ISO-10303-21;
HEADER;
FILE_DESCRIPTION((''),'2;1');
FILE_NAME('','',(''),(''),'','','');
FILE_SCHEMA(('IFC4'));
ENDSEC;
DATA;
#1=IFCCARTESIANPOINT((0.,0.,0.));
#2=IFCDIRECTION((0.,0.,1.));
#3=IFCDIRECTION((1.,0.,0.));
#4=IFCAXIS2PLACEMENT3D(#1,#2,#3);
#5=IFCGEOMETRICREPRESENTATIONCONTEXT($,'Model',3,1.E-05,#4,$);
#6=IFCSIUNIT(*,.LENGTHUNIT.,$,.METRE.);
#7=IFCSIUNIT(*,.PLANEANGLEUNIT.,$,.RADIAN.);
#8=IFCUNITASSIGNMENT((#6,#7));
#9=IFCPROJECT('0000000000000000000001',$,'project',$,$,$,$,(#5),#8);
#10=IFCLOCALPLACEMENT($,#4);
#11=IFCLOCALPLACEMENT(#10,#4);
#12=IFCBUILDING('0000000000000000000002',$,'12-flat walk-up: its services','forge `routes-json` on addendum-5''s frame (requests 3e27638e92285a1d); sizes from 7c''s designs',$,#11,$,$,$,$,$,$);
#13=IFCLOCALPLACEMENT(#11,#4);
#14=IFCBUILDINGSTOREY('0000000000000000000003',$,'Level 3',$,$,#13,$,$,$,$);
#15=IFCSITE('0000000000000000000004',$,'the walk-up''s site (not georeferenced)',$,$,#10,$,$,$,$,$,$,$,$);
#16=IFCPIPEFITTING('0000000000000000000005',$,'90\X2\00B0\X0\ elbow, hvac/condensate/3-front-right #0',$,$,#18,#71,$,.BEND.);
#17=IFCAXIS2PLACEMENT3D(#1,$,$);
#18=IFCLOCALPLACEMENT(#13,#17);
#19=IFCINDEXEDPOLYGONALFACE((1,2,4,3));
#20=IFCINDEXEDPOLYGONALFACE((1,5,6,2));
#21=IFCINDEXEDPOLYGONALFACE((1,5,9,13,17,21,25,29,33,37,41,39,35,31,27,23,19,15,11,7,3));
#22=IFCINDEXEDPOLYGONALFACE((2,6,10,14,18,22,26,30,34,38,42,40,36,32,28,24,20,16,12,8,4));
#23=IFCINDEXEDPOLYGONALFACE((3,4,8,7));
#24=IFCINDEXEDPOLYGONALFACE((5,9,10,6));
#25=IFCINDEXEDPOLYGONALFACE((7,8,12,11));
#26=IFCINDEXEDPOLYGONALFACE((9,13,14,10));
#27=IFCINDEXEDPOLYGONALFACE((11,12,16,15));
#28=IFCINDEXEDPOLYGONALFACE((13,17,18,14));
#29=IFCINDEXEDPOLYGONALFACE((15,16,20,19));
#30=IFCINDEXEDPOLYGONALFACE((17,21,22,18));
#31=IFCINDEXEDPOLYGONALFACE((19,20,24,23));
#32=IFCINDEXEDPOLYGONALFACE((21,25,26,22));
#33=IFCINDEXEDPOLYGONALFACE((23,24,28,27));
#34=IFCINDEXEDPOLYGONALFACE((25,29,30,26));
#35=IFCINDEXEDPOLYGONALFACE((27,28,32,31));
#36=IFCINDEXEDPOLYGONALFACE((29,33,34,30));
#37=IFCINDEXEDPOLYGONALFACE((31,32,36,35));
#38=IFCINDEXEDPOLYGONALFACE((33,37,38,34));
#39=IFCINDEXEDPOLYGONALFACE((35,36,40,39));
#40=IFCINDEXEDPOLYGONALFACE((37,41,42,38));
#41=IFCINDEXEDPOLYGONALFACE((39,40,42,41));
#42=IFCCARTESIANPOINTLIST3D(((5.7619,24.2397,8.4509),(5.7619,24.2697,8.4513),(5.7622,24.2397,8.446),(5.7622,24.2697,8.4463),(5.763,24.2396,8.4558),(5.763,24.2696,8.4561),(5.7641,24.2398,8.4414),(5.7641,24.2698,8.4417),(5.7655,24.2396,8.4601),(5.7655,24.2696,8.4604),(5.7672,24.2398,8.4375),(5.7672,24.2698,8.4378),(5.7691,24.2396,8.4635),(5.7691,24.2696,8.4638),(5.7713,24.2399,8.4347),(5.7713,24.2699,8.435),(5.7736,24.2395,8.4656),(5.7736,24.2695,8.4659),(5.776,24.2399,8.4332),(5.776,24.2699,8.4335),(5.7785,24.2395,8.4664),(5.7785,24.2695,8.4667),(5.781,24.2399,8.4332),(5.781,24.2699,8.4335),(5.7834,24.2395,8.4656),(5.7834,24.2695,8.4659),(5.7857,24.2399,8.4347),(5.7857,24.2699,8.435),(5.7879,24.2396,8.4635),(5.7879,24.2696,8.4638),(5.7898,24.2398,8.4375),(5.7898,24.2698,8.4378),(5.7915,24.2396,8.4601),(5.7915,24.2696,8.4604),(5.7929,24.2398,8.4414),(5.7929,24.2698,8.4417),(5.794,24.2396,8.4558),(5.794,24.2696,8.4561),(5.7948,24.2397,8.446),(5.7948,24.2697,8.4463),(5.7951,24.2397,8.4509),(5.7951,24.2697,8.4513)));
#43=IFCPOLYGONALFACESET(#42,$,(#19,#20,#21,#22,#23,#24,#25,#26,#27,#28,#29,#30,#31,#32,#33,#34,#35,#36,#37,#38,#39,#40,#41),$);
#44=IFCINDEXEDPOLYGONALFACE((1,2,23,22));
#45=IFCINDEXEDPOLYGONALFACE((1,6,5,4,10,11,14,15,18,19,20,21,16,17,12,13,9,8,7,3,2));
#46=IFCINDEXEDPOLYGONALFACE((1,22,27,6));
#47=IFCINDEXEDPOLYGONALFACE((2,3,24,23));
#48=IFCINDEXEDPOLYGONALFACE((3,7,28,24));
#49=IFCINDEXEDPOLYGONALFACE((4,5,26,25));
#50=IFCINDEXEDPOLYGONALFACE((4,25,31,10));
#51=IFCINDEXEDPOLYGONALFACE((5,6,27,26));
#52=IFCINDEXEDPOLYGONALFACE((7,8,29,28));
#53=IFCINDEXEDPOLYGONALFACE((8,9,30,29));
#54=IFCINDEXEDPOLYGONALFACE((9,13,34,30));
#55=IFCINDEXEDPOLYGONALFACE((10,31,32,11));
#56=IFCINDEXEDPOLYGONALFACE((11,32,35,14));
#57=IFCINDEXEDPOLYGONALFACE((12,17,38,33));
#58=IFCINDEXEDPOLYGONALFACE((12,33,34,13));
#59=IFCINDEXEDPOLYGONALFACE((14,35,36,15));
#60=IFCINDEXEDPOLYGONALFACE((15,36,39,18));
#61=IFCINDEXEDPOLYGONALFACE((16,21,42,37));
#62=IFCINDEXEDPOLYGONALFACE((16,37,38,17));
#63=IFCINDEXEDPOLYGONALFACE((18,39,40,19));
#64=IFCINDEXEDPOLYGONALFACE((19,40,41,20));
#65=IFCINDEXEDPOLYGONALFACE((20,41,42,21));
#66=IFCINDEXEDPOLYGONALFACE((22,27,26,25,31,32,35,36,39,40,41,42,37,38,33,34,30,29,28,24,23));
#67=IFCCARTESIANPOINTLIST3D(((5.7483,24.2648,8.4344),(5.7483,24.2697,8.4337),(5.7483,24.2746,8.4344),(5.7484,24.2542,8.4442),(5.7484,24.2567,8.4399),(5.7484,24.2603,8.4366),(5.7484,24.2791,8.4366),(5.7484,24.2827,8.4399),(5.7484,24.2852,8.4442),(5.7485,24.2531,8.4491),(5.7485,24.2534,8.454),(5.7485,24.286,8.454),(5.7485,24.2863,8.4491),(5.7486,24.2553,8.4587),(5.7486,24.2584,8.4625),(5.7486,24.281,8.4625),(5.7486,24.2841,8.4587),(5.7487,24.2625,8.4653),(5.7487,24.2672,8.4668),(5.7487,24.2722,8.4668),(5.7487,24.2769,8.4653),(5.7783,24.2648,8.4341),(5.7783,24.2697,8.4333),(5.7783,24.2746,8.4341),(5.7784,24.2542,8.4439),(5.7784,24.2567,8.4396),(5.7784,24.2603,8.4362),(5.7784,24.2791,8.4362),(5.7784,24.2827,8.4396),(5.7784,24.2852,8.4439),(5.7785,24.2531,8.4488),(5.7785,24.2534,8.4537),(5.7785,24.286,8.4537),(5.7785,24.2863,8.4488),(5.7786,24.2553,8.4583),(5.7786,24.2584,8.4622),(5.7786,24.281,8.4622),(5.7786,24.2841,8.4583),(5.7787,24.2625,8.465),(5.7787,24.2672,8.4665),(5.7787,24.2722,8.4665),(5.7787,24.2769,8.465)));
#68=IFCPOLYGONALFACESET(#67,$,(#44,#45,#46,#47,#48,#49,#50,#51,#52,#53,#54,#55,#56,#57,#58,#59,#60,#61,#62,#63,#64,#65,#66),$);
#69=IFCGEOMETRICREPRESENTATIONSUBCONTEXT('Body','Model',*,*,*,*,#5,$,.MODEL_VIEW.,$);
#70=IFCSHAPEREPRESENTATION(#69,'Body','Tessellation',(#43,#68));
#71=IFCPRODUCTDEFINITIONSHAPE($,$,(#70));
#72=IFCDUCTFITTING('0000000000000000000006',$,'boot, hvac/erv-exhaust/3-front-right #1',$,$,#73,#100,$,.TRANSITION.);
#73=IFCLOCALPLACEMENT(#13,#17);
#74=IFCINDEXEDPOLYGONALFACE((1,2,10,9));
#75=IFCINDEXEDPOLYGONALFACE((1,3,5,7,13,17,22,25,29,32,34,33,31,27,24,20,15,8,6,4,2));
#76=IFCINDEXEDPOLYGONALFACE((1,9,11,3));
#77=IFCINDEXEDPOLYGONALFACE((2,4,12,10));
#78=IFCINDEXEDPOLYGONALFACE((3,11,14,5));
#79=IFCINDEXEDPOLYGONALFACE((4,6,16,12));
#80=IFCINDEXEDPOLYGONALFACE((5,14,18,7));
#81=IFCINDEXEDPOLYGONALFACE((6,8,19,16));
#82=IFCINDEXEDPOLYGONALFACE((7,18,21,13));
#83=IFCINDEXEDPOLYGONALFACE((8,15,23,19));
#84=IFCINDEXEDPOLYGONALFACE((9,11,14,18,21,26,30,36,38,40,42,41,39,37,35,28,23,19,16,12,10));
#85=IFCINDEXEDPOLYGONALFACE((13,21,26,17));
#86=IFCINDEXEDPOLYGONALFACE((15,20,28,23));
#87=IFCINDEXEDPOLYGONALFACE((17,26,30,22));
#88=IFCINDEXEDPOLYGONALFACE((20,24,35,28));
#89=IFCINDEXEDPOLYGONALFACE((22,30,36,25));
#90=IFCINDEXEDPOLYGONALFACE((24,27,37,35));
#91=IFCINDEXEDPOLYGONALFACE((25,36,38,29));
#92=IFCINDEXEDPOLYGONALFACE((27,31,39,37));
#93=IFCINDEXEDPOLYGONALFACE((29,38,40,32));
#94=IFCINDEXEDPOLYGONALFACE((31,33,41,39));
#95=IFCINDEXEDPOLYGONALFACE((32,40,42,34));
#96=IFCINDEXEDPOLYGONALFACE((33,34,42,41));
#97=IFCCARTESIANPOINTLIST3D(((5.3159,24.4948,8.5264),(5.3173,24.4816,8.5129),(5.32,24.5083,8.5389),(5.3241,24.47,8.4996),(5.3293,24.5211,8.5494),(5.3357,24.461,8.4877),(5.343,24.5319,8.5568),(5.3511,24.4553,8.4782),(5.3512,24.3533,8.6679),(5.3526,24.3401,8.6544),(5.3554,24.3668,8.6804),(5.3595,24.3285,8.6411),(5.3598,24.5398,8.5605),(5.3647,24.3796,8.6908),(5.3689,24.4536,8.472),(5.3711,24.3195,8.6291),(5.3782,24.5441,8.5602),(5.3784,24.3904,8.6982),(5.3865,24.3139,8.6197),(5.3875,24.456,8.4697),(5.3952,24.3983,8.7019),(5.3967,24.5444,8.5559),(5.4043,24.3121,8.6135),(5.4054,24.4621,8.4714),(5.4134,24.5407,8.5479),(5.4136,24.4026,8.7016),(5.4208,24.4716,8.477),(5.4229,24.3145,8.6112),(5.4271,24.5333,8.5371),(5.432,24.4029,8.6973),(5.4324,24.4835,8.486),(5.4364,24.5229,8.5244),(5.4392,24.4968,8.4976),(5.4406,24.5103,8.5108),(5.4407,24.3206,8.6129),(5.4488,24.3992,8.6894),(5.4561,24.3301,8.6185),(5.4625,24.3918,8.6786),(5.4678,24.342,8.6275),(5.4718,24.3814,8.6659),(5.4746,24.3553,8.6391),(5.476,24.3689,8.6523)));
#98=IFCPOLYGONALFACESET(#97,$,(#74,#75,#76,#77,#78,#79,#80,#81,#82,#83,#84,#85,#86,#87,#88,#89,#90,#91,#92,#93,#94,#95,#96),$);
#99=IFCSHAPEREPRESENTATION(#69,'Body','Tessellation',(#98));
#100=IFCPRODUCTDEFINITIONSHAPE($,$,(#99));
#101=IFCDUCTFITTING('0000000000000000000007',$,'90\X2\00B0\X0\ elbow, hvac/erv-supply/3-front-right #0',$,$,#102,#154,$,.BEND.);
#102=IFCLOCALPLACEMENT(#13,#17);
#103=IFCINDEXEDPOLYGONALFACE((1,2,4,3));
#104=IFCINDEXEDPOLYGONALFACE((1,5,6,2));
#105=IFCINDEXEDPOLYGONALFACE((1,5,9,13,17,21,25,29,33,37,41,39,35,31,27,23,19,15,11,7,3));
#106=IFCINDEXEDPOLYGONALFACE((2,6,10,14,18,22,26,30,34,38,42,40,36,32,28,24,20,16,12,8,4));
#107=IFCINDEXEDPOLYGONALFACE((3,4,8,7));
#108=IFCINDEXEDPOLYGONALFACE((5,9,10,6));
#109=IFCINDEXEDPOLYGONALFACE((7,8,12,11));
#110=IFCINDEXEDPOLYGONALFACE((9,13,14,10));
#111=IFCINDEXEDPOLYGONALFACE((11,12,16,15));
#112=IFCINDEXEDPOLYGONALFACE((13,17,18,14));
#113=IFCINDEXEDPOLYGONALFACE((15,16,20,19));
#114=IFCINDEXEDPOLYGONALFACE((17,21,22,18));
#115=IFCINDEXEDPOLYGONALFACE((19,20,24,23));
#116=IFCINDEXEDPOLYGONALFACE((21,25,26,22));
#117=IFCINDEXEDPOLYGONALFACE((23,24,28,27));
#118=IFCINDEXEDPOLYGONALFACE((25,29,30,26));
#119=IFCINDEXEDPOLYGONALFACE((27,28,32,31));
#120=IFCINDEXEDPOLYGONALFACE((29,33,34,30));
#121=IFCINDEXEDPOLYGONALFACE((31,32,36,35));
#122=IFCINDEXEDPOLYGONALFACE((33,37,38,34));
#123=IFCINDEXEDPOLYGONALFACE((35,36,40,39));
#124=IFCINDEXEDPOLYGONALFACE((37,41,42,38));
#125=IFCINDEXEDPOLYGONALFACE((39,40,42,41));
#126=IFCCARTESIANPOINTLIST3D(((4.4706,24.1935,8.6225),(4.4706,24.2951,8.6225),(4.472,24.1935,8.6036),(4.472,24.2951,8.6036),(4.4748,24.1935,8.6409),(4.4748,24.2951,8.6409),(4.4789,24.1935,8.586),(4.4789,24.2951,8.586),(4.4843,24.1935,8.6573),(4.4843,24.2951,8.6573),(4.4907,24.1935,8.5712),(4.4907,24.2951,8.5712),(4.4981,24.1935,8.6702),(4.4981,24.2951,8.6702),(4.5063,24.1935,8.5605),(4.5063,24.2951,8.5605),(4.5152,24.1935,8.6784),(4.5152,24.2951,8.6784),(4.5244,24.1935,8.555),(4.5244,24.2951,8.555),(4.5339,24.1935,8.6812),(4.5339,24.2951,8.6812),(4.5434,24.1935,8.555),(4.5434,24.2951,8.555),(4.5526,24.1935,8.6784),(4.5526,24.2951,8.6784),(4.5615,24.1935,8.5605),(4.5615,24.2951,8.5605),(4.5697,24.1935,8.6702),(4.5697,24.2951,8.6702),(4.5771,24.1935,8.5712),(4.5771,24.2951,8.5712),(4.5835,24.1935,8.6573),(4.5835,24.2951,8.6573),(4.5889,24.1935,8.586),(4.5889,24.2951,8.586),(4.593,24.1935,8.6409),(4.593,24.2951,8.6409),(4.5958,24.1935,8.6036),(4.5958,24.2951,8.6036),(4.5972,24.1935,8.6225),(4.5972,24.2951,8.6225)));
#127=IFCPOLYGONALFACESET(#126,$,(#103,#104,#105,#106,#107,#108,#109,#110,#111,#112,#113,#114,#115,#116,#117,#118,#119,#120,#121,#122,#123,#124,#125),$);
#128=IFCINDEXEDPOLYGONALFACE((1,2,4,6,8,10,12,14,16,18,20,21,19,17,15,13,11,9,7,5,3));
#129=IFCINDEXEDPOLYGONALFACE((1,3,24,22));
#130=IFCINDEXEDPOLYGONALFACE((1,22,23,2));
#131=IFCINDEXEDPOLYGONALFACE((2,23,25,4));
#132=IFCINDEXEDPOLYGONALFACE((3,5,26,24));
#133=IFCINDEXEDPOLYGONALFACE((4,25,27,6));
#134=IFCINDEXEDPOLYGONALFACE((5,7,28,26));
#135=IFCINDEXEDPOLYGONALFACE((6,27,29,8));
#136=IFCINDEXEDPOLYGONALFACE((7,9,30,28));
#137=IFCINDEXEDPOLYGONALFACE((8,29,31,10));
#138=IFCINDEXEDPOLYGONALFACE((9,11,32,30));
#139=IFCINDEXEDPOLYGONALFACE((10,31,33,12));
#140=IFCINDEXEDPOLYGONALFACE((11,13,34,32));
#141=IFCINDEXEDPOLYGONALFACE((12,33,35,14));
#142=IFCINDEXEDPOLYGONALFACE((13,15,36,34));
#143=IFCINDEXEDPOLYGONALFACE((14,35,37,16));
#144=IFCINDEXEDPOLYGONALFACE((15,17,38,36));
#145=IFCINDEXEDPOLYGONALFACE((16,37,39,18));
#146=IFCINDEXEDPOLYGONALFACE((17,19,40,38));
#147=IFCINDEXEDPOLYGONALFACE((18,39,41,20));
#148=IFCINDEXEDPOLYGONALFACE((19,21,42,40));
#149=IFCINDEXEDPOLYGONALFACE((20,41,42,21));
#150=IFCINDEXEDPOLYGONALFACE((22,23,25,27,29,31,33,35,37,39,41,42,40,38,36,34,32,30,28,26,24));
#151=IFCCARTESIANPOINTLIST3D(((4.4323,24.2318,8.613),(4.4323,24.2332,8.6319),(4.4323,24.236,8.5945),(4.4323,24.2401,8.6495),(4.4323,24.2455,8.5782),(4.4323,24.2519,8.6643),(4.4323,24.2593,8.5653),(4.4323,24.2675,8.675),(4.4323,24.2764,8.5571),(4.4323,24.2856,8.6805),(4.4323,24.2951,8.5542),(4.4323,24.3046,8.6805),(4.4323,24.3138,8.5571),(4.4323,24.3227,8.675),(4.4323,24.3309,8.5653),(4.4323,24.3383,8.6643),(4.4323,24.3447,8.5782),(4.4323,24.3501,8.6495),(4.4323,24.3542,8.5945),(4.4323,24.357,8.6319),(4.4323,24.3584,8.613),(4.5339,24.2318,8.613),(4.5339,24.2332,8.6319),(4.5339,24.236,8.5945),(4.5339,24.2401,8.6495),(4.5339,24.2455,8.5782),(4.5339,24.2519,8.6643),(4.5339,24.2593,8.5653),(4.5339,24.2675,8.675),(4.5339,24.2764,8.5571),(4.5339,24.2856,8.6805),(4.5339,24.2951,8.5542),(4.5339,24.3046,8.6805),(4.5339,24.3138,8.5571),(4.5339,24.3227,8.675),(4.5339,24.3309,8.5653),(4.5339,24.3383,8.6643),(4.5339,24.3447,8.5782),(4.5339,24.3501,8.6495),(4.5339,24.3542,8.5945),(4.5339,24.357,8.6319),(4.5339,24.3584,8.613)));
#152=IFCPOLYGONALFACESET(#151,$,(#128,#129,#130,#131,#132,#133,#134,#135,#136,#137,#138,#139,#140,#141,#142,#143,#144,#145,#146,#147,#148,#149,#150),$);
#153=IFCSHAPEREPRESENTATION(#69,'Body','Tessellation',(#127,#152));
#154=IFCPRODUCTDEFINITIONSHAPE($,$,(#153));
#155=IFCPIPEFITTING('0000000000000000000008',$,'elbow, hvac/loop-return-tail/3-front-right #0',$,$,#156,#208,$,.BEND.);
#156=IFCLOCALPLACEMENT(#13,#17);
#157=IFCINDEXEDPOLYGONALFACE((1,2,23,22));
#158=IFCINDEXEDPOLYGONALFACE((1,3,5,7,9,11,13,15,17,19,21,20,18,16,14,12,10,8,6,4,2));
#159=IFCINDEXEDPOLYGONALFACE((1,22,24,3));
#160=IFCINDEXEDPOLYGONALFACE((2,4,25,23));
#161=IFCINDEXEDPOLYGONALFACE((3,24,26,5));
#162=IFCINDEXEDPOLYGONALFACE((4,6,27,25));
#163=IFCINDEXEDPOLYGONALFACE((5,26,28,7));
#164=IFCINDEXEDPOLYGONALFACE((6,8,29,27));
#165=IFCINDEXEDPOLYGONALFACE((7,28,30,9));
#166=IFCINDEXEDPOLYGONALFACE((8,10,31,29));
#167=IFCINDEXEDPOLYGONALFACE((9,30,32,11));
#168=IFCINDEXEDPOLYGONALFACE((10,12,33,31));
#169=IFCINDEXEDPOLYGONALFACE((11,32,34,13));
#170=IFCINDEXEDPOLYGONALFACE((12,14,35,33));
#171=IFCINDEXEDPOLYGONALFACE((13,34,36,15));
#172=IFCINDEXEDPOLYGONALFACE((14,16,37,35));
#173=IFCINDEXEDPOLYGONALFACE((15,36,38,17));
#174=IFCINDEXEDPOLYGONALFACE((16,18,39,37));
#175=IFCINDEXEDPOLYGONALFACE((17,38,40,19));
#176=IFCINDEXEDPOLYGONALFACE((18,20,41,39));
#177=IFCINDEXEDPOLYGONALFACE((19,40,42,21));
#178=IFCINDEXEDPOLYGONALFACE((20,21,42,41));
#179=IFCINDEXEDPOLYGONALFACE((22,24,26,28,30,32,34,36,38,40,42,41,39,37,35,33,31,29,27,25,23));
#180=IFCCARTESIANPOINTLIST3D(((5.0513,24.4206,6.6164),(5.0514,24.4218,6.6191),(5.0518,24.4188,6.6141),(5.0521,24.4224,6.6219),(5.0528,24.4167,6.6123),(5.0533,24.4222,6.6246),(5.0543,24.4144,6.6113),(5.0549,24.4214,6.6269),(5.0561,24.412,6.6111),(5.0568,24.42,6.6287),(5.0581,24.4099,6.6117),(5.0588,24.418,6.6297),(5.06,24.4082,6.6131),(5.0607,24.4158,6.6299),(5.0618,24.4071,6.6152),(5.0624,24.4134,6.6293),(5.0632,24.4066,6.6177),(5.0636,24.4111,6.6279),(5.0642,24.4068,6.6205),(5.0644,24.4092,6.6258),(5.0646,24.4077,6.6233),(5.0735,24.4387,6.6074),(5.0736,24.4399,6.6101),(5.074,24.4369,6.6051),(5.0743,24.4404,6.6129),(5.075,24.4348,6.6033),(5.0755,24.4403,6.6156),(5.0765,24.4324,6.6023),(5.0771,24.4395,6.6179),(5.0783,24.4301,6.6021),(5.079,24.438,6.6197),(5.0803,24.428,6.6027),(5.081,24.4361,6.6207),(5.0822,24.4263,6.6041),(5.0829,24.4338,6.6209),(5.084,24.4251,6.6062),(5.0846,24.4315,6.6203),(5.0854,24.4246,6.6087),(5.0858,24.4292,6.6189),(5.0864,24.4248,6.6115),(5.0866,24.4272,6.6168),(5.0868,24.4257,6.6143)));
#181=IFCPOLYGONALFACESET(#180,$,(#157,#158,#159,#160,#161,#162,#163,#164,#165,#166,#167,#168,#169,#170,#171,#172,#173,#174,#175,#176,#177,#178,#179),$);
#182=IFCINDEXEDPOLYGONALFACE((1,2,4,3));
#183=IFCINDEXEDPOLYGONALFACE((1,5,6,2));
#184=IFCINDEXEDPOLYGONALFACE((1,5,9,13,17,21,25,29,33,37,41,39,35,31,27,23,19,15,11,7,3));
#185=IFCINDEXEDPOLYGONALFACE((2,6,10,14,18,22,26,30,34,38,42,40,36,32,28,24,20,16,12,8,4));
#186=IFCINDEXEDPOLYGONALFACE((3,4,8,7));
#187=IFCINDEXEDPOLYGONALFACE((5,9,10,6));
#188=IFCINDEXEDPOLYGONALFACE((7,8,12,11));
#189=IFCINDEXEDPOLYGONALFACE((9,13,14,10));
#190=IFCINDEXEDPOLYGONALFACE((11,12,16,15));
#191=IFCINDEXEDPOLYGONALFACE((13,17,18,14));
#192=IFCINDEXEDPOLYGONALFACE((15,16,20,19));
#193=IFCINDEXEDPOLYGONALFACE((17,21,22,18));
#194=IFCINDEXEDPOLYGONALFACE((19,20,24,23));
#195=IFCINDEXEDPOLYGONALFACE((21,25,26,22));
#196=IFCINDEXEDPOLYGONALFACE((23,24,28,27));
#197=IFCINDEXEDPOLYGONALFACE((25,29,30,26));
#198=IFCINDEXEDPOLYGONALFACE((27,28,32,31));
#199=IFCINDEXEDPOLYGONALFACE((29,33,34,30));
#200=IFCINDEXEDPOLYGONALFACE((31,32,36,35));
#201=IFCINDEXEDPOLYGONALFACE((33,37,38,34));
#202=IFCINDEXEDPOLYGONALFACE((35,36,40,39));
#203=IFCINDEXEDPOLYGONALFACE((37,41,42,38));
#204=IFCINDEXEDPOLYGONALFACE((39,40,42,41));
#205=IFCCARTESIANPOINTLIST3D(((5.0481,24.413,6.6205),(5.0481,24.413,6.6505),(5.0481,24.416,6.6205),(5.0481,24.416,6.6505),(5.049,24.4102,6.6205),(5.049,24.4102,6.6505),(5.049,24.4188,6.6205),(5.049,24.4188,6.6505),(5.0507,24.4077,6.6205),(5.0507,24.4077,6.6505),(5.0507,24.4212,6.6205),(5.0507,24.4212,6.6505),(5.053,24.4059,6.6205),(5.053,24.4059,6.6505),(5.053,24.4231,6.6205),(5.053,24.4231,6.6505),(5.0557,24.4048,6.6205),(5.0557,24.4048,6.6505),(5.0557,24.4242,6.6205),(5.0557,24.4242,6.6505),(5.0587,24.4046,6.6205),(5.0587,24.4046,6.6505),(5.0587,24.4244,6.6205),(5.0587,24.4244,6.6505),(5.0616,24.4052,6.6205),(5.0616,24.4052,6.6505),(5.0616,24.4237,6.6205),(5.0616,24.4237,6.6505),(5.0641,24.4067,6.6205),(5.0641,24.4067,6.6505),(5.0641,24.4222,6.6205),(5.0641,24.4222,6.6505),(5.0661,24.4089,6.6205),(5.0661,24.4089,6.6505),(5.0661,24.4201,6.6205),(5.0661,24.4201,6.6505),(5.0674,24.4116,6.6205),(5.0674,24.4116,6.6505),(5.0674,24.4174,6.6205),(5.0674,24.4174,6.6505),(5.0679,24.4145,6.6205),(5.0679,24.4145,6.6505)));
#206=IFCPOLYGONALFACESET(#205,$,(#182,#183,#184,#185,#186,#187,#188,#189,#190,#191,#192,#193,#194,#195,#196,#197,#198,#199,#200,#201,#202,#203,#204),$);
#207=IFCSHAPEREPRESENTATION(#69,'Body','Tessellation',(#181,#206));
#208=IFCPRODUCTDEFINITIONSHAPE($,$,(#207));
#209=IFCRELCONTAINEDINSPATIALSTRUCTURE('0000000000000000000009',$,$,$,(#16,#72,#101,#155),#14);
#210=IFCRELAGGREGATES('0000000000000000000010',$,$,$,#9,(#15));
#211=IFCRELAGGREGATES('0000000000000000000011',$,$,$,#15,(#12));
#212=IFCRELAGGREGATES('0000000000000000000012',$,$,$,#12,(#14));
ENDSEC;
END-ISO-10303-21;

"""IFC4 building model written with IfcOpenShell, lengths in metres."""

from ifc_helpers import new_model, entity, si_unit, frame, origin_with_axes, place, context, subcontext, project, spatial, element, save


model = new_model("IFC4")

# Units and contexts
model_context = context("Model", 3, precision=1e-05, world=origin_with_axes())
body_context = subcontext(model_context, "Body", "Model", "MODEL_VIEW")
ifc_project = project(units=[si_unit("LENGTHUNIT", "METRE"), si_unit("PLANEANGLEUNIT", "RADIAN")], contexts=[model_context])

# Site, building, storey
site_placement = place(None, origin_with_axes())
site = spatial("IfcSite", under=ifc_project, at=site_placement, Name="the walk-up's site (not georeferenced)")
building_placement = place(site_placement, origin_with_axes())
building = spatial("IfcBuilding", under=site, at=building_placement, Name="12-flat walk-up: its services", Description="forge `routes-json` on addendum-5's frame (requests 3e27638e92285a1d); sizes from 7c's designs")
storey_placement = place(building_placement, origin_with_axes())
storey = spatial("IfcBuildingStorey", under=building, at=storey_placement, Name="Level 3")

# Pipe fitting
pipe_fitting_1_placement = place(storey_placement, frame((5.7785, 24.2397, 8.4497), z_axis=(0.0, 0.0, 1.0), x_axis=(1.0, 0.0, 0.0)))
element("IfcPipeFitting", 1, at=pipe_fitting_1_placement, inside=storey, Name="90° elbow, hvac/condensate/3-front-right #0", PredefinedType="BEND", context=body_context, shape_type="AdvancedSweptSolid", body=[
    entity("IfcSweptDiskSolid", entity("IfcPolyline", [entity("IfcCartesianPoint", [0.0, 0.0, 0.0]), entity("IfcCartesianPoint", [0.0, 0.03, 0.0003])]), 0.0167),
    entity("IfcSweptDiskSolid", entity("IfcPolyline", [entity("IfcCartesianPoint", [0.0, 0.03, 0.0003]), entity("IfcCartesianPoint", [-0.03, 0.03, 0.0006])]), 0.0167),
])

# Duct fittings
duct_fitting_1_placement = place(storey_placement, frame((5.4136, 24.3577, 8.6567), z_axis=(0.0, 0.0, 1.0), x_axis=(1.0, 0.0, 0.0)))
element("IfcDuctFitting", 2, at=duct_fitting_1_placement, inside=storey, Name="boot, hvac/erv-exhaust/3-front-right #1", PredefinedType="TRANSITION", context=body_context, shape_type="AdvancedSweptSolid", body=[
    entity("IfcSweptDiskSolid", entity("IfcPolyline", [entity("IfcCartesianPoint", [0.0, 0.0, 0.0]), entity("IfcCartesianPoint", [-0.0354, 0.1415, -0.1415])]), 0.0635),
])
duct_fitting_2_placement = place(storey_placement, frame((4.5339, 24.1935, 8.6177), z_axis=(0.0, 0.0, 1.0), x_axis=(1.0, 0.0, 0.0)))
element("IfcDuctFitting", 3, at=duct_fitting_2_placement, inside=storey, Name="90° elbow, hvac/erv-supply/3-front-right #0", PredefinedType="BEND", context=body_context, shape_type="AdvancedSweptSolid", body=[
    entity("IfcSweptDiskSolid", entity("IfcPolyline", [entity("IfcCartesianPoint", [0.0, 0.0, 0.0]), entity("IfcCartesianPoint", [0.0, 0.1016, 0.0])]), 0.0635),
    entity("IfcSweptDiskSolid", entity("IfcPolyline", [entity("IfcCartesianPoint", [0.0, 0.1016, 0.0]), entity("IfcCartesianPoint", [-0.1016, 0.1016, 0.0])]), 0.0635),
])

# Pipe fitting
pipe_fitting_2_placement = place(storey_placement, frame((5.0801, 24.4325, 6.6115), z_axis=(0.0, 0.0, 1.0), x_axis=(1.0, 0.0, 0.0)))
element("IfcPipeFitting", 4, at=pipe_fitting_2_placement, inside=storey, Name="elbow, hvac/loop-return-tail/3-front-right #0", PredefinedType="BEND", context=body_context, shape_type="AdvancedSweptSolid", body=[
    entity("IfcSweptDiskSolid", entity("IfcPolyline", [entity("IfcCartesianPoint", [0.0, 0.0, 0.0]), entity("IfcCartesianPoint", [-0.0222, -0.0181, 0.009])]), 0.0099),
    entity("IfcSweptDiskSolid", entity("IfcPolyline", [entity("IfcCartesianPoint", [-0.0222, -0.0181, 0.009]), entity("IfcCartesianPoint", [-0.0222, -0.0181, 0.039])]), 0.0099),
])

save(model, "model.ifc")
